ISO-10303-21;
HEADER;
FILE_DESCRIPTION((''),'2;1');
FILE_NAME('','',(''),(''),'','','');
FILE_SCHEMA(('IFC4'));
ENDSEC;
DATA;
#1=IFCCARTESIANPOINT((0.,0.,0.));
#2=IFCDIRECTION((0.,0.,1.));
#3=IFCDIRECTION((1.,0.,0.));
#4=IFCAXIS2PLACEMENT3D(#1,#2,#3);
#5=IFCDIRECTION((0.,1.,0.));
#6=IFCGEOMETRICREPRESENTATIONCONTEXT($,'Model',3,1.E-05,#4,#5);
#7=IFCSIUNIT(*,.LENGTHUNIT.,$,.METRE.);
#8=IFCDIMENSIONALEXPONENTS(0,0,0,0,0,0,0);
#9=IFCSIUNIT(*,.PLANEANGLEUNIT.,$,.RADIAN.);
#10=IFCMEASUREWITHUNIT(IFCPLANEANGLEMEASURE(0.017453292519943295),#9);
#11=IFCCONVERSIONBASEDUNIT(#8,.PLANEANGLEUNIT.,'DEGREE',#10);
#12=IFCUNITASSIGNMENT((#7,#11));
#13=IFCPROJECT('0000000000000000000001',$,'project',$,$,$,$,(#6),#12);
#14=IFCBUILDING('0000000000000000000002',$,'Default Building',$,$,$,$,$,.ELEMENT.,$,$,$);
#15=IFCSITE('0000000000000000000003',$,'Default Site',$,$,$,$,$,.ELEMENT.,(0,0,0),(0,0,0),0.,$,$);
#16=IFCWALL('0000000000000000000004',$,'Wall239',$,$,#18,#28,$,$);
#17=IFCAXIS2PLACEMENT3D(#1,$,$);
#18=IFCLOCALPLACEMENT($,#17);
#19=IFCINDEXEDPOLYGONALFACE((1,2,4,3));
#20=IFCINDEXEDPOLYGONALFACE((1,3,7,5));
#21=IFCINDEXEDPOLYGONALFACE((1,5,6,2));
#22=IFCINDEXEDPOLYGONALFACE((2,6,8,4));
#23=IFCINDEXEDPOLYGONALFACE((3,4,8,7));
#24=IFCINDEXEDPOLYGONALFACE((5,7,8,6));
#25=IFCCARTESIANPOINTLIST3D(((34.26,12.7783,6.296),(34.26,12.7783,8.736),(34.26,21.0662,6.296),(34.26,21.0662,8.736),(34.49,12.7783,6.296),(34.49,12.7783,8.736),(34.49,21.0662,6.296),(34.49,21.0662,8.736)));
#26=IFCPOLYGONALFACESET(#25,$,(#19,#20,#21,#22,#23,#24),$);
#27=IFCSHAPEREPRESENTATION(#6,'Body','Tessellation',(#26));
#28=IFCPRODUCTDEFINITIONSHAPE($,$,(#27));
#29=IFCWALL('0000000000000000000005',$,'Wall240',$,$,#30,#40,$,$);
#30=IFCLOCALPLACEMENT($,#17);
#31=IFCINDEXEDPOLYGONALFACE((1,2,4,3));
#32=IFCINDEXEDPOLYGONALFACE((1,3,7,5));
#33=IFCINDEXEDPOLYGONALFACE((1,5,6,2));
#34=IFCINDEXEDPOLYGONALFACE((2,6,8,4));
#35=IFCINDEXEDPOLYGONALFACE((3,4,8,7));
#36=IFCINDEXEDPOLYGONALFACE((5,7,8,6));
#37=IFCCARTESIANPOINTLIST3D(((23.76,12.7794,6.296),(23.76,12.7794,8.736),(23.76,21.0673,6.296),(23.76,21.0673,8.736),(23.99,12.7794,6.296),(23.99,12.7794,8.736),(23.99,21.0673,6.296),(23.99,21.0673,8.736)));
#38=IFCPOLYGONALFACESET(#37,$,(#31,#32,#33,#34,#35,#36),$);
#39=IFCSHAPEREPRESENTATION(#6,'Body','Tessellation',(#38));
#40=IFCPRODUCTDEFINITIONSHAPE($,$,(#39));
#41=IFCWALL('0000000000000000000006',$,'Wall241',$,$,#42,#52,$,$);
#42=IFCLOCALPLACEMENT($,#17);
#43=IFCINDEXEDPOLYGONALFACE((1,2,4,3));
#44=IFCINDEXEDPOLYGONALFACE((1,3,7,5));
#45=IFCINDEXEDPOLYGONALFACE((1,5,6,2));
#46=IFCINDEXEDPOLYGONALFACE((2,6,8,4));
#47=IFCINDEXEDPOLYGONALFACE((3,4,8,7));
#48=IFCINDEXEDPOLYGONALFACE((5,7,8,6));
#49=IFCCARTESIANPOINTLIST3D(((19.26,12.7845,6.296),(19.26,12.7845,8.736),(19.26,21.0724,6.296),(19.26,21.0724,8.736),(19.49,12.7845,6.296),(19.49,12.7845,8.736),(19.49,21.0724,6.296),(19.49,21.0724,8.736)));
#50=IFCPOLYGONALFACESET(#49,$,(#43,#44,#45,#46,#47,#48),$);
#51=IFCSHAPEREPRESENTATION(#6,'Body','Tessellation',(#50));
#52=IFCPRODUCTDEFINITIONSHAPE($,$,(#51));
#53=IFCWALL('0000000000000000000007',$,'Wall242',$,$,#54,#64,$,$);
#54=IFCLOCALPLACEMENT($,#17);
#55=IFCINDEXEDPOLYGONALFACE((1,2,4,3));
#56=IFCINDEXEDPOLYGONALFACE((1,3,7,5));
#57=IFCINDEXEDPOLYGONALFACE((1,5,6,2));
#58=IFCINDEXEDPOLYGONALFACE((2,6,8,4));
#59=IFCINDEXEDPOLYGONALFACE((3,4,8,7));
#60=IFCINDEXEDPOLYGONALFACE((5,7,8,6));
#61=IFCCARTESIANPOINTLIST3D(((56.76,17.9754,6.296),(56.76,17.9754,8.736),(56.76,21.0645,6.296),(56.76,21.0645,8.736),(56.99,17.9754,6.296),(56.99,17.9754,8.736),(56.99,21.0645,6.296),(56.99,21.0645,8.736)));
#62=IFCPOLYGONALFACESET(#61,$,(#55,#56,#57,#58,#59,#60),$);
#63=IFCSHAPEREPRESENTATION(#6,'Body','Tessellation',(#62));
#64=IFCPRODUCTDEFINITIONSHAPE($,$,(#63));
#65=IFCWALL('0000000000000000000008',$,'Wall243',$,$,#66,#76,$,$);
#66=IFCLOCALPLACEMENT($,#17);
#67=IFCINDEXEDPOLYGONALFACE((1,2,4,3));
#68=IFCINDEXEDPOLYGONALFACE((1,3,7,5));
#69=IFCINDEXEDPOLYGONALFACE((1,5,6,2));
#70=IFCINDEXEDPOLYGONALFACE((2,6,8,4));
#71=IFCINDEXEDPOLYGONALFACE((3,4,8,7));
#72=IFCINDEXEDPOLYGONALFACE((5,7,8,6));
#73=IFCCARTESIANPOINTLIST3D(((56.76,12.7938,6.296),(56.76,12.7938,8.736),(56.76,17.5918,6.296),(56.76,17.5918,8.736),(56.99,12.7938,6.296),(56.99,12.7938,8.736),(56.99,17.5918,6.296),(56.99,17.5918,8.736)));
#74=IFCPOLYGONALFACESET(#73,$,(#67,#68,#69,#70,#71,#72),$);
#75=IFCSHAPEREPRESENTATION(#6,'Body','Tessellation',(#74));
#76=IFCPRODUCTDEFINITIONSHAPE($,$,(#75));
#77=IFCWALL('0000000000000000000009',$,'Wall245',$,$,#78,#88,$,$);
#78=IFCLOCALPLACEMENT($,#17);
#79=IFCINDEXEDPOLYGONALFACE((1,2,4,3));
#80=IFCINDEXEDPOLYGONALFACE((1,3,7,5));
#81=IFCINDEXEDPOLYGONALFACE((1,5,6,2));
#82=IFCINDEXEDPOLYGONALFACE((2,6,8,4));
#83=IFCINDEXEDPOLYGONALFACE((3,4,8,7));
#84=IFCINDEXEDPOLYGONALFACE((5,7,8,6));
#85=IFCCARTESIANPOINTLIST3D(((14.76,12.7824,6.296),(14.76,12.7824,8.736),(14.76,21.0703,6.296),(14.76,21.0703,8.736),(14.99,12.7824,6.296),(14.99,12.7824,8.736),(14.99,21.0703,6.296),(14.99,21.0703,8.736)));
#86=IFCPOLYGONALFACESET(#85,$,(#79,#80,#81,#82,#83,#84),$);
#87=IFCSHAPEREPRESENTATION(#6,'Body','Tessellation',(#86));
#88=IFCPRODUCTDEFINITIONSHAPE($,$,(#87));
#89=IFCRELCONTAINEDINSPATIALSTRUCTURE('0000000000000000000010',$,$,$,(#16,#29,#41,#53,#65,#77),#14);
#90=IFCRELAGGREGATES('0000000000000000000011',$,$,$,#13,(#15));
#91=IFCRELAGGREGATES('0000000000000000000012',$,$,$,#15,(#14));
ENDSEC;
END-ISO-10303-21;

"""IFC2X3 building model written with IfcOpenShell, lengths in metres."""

from ifc_helpers import new_model, entity, si_unit, converted_unit, direction, frame, frame_2d, origin_with_axes, place, context, project, spatial, rectangle, extrude, element, save


model = new_model("IFC2X3")

# Units and contexts
model_context = context("Model", 3, precision=1e-05, world=origin_with_axes(), true_north=direction((0.0, 1.0, 0.0)))
ifc_project = project(units=[si_unit("LENGTHUNIT", "METRE"), converted_unit("PLANEANGLEUNIT", "DEGREE", entity("IfcPlaneAngleMeasure", 0.017453292519943295), si_unit("PLANEANGLEUNIT", "RADIAN"), dimensions=[0, 0, 0, 0, 0, 0, 0])], contexts=[model_context])

# Site, building
site = spatial("IfcSite", under=ifc_project, Name="Default Site", CompositionType="ELEMENT", RefLatitude=(0, 0, 0), RefLongitude=(0, 0, 0), RefElevation=0.0)
building = spatial("IfcBuilding", under=site, Name="Default Building", CompositionType="ELEMENT")

# Shared definitions
placement = place(None, origin_with_axes())

# Walls
element("IfcWall", 1, at=placement, inside=building, Name="Wall239", context=model_context, shape_type="SweptSolid", body=[
    extrude(rectangle(XDim=8.2879, YDim=0.23, at=frame_2d((0.0, 0.0), x_axis=(0.0, 1.0, 0.0))), frame((34.375, 16.9223, 6.296), z_axis=(0.0, 0.0, 1.0), x_axis=(1.0, 0.0, 0.0)), (0.0, 0.0, 1.0), 2.44),
])
element("IfcWall", 2, at=placement, inside=building, Name="Wall240", context=model_context, shape_type="SweptSolid", body=[
    extrude(rectangle(XDim=8.2879, YDim=0.23, at=frame_2d((0.0, 0.0), x_axis=(0.0, 1.0, 0.0))), frame((23.875, 16.9233, 6.296), z_axis=(0.0, 0.0, 1.0), x_axis=(1.0, 0.0, 0.0)), (0.0, 0.0, 1.0), 2.44),
])
element("IfcWall", 3, at=placement, inside=building, Name="Wall241", context=model_context, shape_type="SweptSolid", body=[
    extrude(rectangle(XDim=8.2879, YDim=0.23, at=frame_2d((0.0, 0.0), x_axis=(0.0, 1.0, 0.0))), frame((19.375, 16.9284, 6.296), z_axis=(0.0, 0.0, 1.0), x_axis=(1.0, 0.0, 0.0)), (0.0, 0.0, 1.0), 2.44),
])
element("IfcWall", 4, at=placement, inside=building, Name="Wall242", context=model_context, shape_type="SweptSolid", body=[
    extrude(rectangle(XDim=3.0891, YDim=0.23, at=frame_2d((0.0, 0.0), x_axis=(0.0, -1.0, 0.0))), frame((56.875, 19.52, 6.296), z_axis=(0.0, 0.0, 1.0), x_axis=(1.0, 0.0, 0.0)), (0.0, 0.0, 1.0), 2.44),
])
element("IfcWall", 5, at=placement, inside=building, Name="Wall243", context=model_context, shape_type="SweptSolid", body=[
    extrude(rectangle(XDim=4.798, YDim=0.23, at=frame_2d((0.0, 0.0), x_axis=(0.0, -1.0, 0.0))), frame((56.875, 15.1928, 6.296), z_axis=(0.0, 0.0, 1.0), x_axis=(1.0, 0.0, 0.0)), (0.0, 0.0, 1.0), 2.44),
])
element("IfcWall", 6, at=placement, inside=building, Name="Wall245", context=model_context, shape_type="SweptSolid", body=[
    extrude(rectangle(XDim=8.2879, YDim=0.23, at=frame_2d((0.0, 0.0), x_axis=(0.0, 1.0, 0.0))), frame((14.875, 16.9263, 6.296), z_axis=(0.0, 0.0, 1.0), x_axis=(1.0, 0.0, 0.0)), (0.0, 0.0, 1.0), 2.44),
])

save(model, "model.ifc")
